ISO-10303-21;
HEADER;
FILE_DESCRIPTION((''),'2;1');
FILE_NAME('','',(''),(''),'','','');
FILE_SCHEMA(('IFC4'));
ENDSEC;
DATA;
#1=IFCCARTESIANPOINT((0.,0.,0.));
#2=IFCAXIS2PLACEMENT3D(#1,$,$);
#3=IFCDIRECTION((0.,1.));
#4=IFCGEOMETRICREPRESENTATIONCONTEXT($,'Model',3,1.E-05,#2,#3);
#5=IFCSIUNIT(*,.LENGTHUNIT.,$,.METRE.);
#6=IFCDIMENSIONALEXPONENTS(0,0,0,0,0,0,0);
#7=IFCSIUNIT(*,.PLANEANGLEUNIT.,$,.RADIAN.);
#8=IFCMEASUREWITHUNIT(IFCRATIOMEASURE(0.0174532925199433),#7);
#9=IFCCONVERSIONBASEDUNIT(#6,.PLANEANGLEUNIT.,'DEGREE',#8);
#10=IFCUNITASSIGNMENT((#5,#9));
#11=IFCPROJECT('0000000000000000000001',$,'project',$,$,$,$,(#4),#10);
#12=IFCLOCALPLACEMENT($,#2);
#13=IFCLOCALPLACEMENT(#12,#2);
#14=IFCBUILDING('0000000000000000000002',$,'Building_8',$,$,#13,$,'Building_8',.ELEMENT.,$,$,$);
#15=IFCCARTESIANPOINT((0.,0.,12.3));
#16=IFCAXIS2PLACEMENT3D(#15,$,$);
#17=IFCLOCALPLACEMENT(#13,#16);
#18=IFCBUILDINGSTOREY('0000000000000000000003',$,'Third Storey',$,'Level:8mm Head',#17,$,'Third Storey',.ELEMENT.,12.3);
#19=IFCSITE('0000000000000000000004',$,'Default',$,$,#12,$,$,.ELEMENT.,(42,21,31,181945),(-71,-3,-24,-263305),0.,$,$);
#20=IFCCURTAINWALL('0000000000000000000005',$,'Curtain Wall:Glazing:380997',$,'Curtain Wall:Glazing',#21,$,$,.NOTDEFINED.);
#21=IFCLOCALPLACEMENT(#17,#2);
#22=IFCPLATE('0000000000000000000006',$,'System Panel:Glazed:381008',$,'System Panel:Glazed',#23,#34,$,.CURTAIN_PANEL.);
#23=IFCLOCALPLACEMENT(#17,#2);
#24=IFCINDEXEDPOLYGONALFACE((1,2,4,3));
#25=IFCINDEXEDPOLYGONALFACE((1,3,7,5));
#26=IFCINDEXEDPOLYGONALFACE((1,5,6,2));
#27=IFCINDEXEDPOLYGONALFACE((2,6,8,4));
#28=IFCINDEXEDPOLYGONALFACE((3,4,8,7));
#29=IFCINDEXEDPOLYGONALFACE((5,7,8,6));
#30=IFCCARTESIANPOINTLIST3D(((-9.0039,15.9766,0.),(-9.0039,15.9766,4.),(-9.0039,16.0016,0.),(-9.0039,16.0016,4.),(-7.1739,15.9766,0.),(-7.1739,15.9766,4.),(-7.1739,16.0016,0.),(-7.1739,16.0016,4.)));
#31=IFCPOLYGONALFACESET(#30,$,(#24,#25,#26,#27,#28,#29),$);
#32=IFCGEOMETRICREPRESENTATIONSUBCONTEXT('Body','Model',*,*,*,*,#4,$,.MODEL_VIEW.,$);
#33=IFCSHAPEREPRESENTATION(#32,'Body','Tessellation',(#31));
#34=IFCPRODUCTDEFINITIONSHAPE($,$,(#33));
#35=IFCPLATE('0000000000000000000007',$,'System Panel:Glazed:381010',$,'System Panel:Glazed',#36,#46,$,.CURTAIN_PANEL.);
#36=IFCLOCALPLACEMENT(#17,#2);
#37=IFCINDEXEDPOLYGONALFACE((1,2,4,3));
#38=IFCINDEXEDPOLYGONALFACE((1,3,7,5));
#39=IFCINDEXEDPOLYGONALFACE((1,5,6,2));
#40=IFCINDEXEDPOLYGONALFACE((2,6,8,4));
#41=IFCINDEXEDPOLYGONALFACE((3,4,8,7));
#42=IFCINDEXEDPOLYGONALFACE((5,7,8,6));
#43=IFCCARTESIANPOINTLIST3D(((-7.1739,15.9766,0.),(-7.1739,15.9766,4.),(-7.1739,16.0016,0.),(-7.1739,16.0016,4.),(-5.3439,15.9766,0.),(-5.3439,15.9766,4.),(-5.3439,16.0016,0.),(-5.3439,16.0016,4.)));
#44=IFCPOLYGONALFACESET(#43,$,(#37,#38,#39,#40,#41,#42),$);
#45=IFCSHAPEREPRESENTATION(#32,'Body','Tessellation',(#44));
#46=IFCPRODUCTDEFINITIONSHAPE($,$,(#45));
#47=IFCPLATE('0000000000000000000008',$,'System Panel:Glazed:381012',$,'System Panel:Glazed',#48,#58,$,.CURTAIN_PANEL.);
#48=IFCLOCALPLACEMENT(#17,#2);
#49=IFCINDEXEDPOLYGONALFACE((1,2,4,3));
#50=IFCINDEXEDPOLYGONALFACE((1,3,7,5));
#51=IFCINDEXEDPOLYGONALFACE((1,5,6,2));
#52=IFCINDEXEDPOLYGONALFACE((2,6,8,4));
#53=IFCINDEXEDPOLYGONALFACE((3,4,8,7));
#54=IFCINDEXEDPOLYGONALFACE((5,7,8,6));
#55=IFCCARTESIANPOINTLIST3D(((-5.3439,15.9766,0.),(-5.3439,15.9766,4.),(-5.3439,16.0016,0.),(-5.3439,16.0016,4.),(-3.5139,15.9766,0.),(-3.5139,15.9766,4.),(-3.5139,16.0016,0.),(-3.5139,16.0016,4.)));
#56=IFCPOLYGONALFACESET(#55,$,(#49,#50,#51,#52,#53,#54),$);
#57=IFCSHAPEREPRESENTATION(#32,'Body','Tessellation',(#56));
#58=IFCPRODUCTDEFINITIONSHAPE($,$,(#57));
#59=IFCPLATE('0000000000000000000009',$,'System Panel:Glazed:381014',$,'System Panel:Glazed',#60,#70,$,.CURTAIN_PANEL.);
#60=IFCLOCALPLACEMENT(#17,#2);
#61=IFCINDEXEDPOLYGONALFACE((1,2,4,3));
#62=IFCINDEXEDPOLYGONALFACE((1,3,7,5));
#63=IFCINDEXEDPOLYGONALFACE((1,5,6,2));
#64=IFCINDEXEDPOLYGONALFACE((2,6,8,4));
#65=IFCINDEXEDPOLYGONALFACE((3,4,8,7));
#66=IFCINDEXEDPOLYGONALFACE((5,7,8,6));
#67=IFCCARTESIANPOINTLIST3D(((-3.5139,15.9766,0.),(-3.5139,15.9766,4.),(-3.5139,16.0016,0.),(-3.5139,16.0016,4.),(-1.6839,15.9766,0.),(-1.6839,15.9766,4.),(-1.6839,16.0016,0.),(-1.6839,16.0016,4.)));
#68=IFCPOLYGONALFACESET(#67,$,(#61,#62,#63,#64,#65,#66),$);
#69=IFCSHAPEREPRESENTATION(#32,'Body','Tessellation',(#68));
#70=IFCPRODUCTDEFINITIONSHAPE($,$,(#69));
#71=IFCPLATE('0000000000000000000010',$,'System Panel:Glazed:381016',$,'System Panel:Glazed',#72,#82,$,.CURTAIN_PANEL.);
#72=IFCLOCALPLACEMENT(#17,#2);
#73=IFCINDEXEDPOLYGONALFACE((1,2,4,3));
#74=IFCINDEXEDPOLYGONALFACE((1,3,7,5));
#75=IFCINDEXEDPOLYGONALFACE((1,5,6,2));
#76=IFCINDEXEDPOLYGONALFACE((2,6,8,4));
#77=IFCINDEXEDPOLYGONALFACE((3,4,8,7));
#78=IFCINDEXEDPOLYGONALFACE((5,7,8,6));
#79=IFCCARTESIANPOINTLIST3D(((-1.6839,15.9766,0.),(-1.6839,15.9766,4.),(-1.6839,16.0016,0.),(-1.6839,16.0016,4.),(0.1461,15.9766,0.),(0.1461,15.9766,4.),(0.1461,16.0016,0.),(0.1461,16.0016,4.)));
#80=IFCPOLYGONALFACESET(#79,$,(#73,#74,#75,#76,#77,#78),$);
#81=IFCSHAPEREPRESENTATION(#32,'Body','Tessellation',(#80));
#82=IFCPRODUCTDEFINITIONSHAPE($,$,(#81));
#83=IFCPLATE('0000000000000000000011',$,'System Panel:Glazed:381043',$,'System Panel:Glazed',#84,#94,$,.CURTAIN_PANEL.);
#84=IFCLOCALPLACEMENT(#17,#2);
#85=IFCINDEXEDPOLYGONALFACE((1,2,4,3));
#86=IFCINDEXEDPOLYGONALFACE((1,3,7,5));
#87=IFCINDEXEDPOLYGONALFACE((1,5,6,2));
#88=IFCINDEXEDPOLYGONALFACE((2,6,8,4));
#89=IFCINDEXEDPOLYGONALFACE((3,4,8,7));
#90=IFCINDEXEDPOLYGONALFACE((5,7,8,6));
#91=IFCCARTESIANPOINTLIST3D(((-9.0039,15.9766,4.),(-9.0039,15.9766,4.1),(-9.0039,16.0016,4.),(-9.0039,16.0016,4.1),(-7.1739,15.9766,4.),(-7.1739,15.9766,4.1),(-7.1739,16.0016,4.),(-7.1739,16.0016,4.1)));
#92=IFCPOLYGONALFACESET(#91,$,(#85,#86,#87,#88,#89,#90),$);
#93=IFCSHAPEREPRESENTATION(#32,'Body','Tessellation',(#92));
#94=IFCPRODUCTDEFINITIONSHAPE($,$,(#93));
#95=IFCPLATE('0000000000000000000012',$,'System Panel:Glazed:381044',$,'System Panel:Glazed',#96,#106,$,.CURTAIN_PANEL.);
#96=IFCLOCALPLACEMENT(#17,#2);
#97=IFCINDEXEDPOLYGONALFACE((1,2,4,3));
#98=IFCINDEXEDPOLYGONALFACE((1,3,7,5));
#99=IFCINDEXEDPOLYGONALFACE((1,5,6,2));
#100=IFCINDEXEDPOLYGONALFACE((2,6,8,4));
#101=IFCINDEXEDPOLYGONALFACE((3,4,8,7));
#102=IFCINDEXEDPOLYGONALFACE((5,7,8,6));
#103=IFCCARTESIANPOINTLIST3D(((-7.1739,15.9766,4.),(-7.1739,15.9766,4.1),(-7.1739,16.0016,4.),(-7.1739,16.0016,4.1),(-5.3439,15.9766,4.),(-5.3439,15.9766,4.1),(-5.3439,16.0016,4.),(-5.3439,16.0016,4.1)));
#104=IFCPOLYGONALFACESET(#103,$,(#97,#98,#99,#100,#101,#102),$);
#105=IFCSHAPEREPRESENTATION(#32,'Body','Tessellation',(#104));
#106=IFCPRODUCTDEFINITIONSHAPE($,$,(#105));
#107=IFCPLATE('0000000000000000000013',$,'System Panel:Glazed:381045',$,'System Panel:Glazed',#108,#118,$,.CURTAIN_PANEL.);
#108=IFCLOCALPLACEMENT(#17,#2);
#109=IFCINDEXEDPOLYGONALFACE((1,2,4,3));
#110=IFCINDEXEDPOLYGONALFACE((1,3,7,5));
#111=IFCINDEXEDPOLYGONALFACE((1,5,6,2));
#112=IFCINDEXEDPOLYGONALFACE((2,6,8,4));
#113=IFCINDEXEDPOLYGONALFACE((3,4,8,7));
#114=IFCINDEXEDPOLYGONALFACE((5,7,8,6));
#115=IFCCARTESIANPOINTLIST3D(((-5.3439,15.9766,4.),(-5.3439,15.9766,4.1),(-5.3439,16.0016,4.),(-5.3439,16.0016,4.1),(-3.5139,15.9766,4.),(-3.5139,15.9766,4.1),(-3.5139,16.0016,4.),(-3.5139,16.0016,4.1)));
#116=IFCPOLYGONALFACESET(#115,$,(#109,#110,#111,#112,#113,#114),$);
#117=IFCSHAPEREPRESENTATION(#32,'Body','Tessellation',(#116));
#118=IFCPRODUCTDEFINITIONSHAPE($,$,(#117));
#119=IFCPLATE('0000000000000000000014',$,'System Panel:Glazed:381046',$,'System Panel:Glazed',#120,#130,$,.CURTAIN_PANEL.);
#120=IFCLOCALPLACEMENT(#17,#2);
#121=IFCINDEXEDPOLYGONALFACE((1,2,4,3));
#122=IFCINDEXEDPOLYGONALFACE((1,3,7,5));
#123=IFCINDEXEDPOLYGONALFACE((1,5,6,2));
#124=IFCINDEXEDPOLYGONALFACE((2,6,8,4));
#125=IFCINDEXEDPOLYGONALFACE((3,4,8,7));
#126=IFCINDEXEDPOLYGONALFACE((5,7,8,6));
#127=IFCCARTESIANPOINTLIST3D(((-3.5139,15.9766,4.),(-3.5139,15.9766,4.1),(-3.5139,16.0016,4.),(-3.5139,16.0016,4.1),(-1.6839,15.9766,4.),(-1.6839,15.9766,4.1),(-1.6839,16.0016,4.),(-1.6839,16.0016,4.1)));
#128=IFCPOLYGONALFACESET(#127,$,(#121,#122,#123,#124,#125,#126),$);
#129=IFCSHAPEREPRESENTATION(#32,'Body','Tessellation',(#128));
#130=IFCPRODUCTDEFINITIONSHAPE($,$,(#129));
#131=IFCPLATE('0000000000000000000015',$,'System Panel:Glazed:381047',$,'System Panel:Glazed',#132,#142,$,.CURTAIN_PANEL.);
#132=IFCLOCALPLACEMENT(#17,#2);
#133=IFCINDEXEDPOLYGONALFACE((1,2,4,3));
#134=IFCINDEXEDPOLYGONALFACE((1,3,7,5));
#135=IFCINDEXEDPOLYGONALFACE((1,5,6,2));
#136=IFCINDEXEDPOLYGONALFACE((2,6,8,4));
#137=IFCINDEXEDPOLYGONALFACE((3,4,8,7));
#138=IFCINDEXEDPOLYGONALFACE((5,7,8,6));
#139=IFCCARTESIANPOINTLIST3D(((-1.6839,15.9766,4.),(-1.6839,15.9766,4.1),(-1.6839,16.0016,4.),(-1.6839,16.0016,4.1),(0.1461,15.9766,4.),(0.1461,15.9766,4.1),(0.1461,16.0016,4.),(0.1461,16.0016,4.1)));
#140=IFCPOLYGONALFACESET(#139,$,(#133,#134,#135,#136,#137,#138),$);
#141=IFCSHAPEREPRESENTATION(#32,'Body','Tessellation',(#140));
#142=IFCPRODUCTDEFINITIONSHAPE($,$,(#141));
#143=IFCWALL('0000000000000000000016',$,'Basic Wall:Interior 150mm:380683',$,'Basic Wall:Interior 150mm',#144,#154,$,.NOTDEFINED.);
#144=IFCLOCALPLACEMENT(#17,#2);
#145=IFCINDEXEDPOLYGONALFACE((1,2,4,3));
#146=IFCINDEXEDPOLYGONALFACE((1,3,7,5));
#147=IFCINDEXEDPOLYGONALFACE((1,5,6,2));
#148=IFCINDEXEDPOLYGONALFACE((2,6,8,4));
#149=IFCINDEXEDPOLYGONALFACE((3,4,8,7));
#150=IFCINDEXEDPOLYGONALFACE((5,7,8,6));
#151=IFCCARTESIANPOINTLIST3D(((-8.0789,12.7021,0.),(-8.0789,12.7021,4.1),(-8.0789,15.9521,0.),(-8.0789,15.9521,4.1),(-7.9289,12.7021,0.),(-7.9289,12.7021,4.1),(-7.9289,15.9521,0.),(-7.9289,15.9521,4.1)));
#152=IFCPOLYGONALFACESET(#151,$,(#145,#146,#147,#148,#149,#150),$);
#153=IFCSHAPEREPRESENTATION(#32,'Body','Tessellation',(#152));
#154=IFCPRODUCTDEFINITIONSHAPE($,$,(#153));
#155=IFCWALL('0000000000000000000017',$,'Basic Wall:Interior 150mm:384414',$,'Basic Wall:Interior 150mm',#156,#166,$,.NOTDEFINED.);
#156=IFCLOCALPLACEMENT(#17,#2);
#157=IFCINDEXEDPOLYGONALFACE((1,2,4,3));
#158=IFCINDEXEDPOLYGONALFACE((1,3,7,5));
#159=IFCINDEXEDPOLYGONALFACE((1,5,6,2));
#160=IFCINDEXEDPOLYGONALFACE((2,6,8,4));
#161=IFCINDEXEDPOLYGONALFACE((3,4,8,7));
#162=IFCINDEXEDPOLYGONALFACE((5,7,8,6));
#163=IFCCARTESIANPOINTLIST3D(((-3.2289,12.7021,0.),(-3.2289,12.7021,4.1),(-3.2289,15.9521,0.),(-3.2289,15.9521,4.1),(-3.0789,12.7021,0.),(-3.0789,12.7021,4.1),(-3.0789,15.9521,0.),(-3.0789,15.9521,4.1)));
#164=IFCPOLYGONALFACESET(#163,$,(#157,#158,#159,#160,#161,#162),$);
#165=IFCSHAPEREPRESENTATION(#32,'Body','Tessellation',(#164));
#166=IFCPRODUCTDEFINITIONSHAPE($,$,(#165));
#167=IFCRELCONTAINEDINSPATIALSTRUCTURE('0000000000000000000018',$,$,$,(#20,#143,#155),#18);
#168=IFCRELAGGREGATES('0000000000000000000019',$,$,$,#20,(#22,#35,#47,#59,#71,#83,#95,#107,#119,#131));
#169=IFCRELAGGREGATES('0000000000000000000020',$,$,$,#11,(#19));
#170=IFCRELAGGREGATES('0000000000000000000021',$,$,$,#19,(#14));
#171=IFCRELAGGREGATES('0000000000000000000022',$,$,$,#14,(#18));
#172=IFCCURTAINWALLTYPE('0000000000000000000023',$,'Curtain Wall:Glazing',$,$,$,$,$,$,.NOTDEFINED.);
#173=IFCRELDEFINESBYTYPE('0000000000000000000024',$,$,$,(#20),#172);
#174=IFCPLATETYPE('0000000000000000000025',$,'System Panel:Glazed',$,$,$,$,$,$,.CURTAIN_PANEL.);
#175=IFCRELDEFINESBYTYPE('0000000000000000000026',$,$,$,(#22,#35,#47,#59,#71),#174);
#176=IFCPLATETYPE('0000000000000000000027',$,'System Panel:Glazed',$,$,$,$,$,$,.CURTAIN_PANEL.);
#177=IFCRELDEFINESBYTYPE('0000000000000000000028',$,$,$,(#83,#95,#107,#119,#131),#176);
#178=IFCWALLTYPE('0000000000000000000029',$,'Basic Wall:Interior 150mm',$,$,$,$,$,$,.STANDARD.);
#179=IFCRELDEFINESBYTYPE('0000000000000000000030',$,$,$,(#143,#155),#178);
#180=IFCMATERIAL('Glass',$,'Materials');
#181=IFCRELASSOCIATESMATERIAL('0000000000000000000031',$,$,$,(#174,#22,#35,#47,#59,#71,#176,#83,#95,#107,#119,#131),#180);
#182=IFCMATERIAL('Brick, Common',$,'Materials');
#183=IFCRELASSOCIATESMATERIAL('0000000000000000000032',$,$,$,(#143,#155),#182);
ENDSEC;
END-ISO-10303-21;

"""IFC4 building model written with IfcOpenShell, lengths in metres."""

from ifc_helpers import new_model, entity, si_unit, converted_unit, direction, frame, origin, place, context, subcontext, project, spatial, indexed_curve, outline, extrude, source, transform, mapped, material, type_object, type_shapes, element, aggregate, save


model = new_model("IFC4")

# Units and contexts
model_context = context("Model", 3, precision=1e-05, world=origin(), true_north=direction((0.0, 1.0)))
body_context = subcontext(model_context, "Body", "Model", "MODEL_VIEW")
ifc_project = project(units=[si_unit("LENGTHUNIT", "METRE"), converted_unit("PLANEANGLEUNIT", "DEGREE", entity("IfcRatioMeasure", 0.0174532925199433), si_unit("PLANEANGLEUNIT", "RADIAN"), dimensions=[0, 0, 0, 0, 0, 0, 0])], contexts=[model_context])

# Site, building, storey
site_placement = place(None, origin())
site = spatial("IfcSite", under=ifc_project, at=site_placement, Name="Default", CompositionType="ELEMENT", RefLatitude=(42, 21, 31, 181945), RefLongitude=(-71, -3, -24, -263305), RefElevation=0.0)
building_placement = place(site_placement, origin())
building = spatial("IfcBuilding", under=site, at=building_placement, Name="Building_8", LongName="Building_8", CompositionType="ELEMENT")
storey_placement = place(building_placement, frame((0.0, 0.0, 12.3)))
storey = spatial("IfcBuildingStorey", under=building, at=storey_placement, Name="Third Storey", ObjectType="Level:8mm Head", LongName="Third Storey", CompositionType="ELEMENT", Elevation=12.3)

# Curtain wall, plates
curtain_wall_type = type_object("IfcCurtainWallType", Name="Curtain Wall:Glazing", PredefinedType="NOTDEFINED")
curtain_wall_placement = place(storey_placement, frame((0.0, 0.0, -12.3)))
curtain_wall = element("IfcCurtainWall", 1, at=curtain_wall_placement, inside=storey, type_object=curtain_wall_type, Name="Curtain Wall:Glazing:380997", ObjectType="Curtain Wall:Glazing", PredefinedType="NOTDEFINED")
ifc_material_1 = material(Name="Glass", Category="Materials")
plate_type_1 = type_object("IfcPlateType", Name="System Panel:Glazed", PredefinedType="CURTAIN_PANEL", material=ifc_material_1)
shared_shape_1 = source(origin(), body_context, "Body", "SweptSolid", [
    extrude(outline(indexed_curve([(-0.0125, -0.915), (0.0125, -0.915), (0.0125, 0.915), (-0.0125, 0.915), (-0.0125, -0.915)], self_intersect=False)), frame((0.0, 0.037, 0.0), z_axis=(0.0, 0.0, 1.0), x_axis=(0.0, 1.0, 0.0)), (0.0, 0.0, 1.0), 4.0),
])
type_shapes(plate_type_1, [shared_shape_1])
plate_1_placement = place(curtain_wall_placement, frame((-8.0889, 15.9521, 12.3)))
plate_1 = element("IfcPlate", 2, at=plate_1_placement, type_object=plate_type_1, material=ifc_material_1, Name="System Panel:Glazed:381008", ObjectType="System Panel:Glazed", PredefinedType="CURTAIN_PANEL", context=body_context, shape_type="MappedRepresentation", body=[
    mapped(shared_shape_1, transform((0.0, 0.0, 0.0), scale=1.0)),
])
plate_2_placement = place(curtain_wall_placement, frame((-6.2589, 15.9521, 12.3)))
plate_2 = element("IfcPlate", 3, at=plate_2_placement, type_object=plate_type_1, material=ifc_material_1, Name="System Panel:Glazed:381010", ObjectType="System Panel:Glazed", PredefinedType="CURTAIN_PANEL", context=body_context, shape_type="MappedRepresentation", body=[
    mapped(shared_shape_1, transform((0.0, 0.0, 0.0), scale=1.0)),
])
plate_3_placement = place(curtain_wall_placement, frame((-4.4289, 15.9521, 12.3)))
plate_3 = element("IfcPlate", 4, at=plate_3_placement, type_object=plate_type_1, material=ifc_material_1, Name="System Panel:Glazed:381012", ObjectType="System Panel:Glazed", PredefinedType="CURTAIN_PANEL", context=body_context, shape_type="MappedRepresentation", body=[
    mapped(shared_shape_1, transform((0.0, 0.0, 0.0), scale=1.0)),
])
plate_4_placement = place(curtain_wall_placement, frame((-2.5989, 15.9521, 12.3)))
plate_4 = element("IfcPlate", 5, at=plate_4_placement, type_object=plate_type_1, material=ifc_material_1, Name="System Panel:Glazed:381014", ObjectType="System Panel:Glazed", PredefinedType="CURTAIN_PANEL", context=body_context, shape_type="MappedRepresentation", body=[
    mapped(shared_shape_1, transform((0.0, 0.0, 0.0), scale=1.0)),
])
plate_5_placement = place(curtain_wall_placement, frame((-0.7689, 15.9521, 12.3)))
plate_5 = element("IfcPlate", 6, at=plate_5_placement, type_object=plate_type_1, material=ifc_material_1, Name="System Panel:Glazed:381016", ObjectType="System Panel:Glazed", PredefinedType="CURTAIN_PANEL", context=body_context, shape_type="MappedRepresentation", body=[
    mapped(shared_shape_1, transform((0.0, 0.0, 0.0), scale=1.0)),
])
plate_type_2 = type_object("IfcPlateType", Name="System Panel:Glazed", PredefinedType="CURTAIN_PANEL", material=ifc_material_1)
shared_shape_2 = source(origin(), body_context, "Body", "SweptSolid", [
    extrude(outline(indexed_curve([(-0.0125, -0.915), (0.0125, -0.915), (0.0125, 0.915), (-0.0125, 0.915), (-0.0125, -0.915)], self_intersect=False)), frame((0.0, 0.037, 0.0), z_axis=(0.0, 0.0, 1.0), x_axis=(0.0, 1.0, 0.0)), (0.0, 0.0, 1.0), 0.1),
])
type_shapes(plate_type_2, [shared_shape_2])
plate_6_placement = place(curtain_wall_placement, frame((-8.0889, 15.9521, 16.3)))
plate_6 = element("IfcPlate", 7, at=plate_6_placement, type_object=plate_type_2, material=ifc_material_1, Name="System Panel:Glazed:381043", ObjectType="System Panel:Glazed", PredefinedType="CURTAIN_PANEL", context=body_context, shape_type="MappedRepresentation", body=[
    mapped(shared_shape_2, transform((0.0, 0.0, 0.0), scale=1.0)),
])
plate_7_placement = place(curtain_wall_placement, frame((-6.2589, 15.9521, 16.3)))
plate_7 = element("IfcPlate", 8, at=plate_7_placement, type_object=plate_type_2, material=ifc_material_1, Name="System Panel:Glazed:381044", ObjectType="System Panel:Glazed", PredefinedType="CURTAIN_PANEL", context=body_context, shape_type="MappedRepresentation", body=[
    mapped(shared_shape_2, transform((0.0, 0.0, 0.0), scale=1.0)),
])
plate_8_placement = place(curtain_wall_placement, frame((-4.4289, 15.9521, 16.3)))
plate_8 = element("IfcPlate", 9, at=plate_8_placement, type_object=plate_type_2, material=ifc_material_1, Name="System Panel:Glazed:381045", ObjectType="System Panel:Glazed", PredefinedType="CURTAIN_PANEL", context=body_context, shape_type="MappedRepresentation", body=[
    mapped(shared_shape_2, transform((0.0, 0.0, 0.0), scale=1.0)),
])
plate_9_placement = place(curtain_wall_placement, frame((-2.5989, 15.9521, 16.3)))
plate_9 = element("IfcPlate", 10, at=plate_9_placement, type_object=plate_type_2, material=ifc_material_1, Name="System Panel:Glazed:381046", ObjectType="System Panel:Glazed", PredefinedType="CURTAIN_PANEL", context=body_context, shape_type="MappedRepresentation", body=[
    mapped(shared_shape_2, transform((0.0, 0.0, 0.0), scale=1.0)),
])
plate_10_placement = place(curtain_wall_placement, frame((-0.7689, 15.9521, 16.3)))
plate_10 = element("IfcPlate", 11, at=plate_10_placement, type_object=plate_type_2, material=ifc_material_1, Name="System Panel:Glazed:381047", ObjectType="System Panel:Glazed", PredefinedType="CURTAIN_PANEL", context=body_context, shape_type="MappedRepresentation", body=[
    mapped(shared_shape_2, transform((0.0, 0.0, 0.0), scale=1.0)),
])
aggregate(curtain_wall, [plate_1, plate_2, plate_3, plate_4, plate_5, plate_6, plate_7, plate_8, plate_9, plate_10])

# Walls
ifc_material_2 = material(Name="Brick, Common", Category="Materials")
wall_type = type_object("IfcWallType", Name="Basic Wall:Interior 150mm", PredefinedType="STANDARD")
wall_1_placement = place(storey_placement, frame((-8.0039, 15.9521, 0.0), z_axis=(0.0, 0.0, 1.0), x_axis=(0.0, -1.0, 0.0)))
element("IfcWall", 12, at=wall_1_placement, inside=storey, type_object=wall_type, material=ifc_material_2, Name="Basic Wall:Interior 150mm:380683", ObjectType="Basic Wall:Interior 150mm", PredefinedType="NOTDEFINED", context=body_context, shape_type="SweptSolid", body=[
    extrude(outline(indexed_curve([(3.25, -0.075), (3.25, 0.075), (0.0, 0.075), (0.0, -0.075), (3.25, -0.075)], self_intersect=False)), origin(), (0.0, 0.0, 1.0), 4.1),
])
wall_2_placement = place(storey_placement, frame((-3.1539, 15.9521, 0.0), z_axis=(0.0, 0.0, 1.0), x_axis=(0.0, -1.0, 0.0)))
element("IfcWall", 13, at=wall_2_placement, inside=storey, type_object=wall_type, material=ifc_material_2, Name="Basic Wall:Interior 150mm:384414", ObjectType="Basic Wall:Interior 150mm", PredefinedType="NOTDEFINED", context=body_context, shape_type="SweptSolid", body=[
    extrude(outline(indexed_curve([(3.25, -0.075), (3.25, 0.075), (0.0, 0.075), (0.0, -0.075), (3.25, -0.075)], self_intersect=False)), origin(), (0.0, 0.0, 1.0), 4.1),
])

save(model, "model.ifc")
